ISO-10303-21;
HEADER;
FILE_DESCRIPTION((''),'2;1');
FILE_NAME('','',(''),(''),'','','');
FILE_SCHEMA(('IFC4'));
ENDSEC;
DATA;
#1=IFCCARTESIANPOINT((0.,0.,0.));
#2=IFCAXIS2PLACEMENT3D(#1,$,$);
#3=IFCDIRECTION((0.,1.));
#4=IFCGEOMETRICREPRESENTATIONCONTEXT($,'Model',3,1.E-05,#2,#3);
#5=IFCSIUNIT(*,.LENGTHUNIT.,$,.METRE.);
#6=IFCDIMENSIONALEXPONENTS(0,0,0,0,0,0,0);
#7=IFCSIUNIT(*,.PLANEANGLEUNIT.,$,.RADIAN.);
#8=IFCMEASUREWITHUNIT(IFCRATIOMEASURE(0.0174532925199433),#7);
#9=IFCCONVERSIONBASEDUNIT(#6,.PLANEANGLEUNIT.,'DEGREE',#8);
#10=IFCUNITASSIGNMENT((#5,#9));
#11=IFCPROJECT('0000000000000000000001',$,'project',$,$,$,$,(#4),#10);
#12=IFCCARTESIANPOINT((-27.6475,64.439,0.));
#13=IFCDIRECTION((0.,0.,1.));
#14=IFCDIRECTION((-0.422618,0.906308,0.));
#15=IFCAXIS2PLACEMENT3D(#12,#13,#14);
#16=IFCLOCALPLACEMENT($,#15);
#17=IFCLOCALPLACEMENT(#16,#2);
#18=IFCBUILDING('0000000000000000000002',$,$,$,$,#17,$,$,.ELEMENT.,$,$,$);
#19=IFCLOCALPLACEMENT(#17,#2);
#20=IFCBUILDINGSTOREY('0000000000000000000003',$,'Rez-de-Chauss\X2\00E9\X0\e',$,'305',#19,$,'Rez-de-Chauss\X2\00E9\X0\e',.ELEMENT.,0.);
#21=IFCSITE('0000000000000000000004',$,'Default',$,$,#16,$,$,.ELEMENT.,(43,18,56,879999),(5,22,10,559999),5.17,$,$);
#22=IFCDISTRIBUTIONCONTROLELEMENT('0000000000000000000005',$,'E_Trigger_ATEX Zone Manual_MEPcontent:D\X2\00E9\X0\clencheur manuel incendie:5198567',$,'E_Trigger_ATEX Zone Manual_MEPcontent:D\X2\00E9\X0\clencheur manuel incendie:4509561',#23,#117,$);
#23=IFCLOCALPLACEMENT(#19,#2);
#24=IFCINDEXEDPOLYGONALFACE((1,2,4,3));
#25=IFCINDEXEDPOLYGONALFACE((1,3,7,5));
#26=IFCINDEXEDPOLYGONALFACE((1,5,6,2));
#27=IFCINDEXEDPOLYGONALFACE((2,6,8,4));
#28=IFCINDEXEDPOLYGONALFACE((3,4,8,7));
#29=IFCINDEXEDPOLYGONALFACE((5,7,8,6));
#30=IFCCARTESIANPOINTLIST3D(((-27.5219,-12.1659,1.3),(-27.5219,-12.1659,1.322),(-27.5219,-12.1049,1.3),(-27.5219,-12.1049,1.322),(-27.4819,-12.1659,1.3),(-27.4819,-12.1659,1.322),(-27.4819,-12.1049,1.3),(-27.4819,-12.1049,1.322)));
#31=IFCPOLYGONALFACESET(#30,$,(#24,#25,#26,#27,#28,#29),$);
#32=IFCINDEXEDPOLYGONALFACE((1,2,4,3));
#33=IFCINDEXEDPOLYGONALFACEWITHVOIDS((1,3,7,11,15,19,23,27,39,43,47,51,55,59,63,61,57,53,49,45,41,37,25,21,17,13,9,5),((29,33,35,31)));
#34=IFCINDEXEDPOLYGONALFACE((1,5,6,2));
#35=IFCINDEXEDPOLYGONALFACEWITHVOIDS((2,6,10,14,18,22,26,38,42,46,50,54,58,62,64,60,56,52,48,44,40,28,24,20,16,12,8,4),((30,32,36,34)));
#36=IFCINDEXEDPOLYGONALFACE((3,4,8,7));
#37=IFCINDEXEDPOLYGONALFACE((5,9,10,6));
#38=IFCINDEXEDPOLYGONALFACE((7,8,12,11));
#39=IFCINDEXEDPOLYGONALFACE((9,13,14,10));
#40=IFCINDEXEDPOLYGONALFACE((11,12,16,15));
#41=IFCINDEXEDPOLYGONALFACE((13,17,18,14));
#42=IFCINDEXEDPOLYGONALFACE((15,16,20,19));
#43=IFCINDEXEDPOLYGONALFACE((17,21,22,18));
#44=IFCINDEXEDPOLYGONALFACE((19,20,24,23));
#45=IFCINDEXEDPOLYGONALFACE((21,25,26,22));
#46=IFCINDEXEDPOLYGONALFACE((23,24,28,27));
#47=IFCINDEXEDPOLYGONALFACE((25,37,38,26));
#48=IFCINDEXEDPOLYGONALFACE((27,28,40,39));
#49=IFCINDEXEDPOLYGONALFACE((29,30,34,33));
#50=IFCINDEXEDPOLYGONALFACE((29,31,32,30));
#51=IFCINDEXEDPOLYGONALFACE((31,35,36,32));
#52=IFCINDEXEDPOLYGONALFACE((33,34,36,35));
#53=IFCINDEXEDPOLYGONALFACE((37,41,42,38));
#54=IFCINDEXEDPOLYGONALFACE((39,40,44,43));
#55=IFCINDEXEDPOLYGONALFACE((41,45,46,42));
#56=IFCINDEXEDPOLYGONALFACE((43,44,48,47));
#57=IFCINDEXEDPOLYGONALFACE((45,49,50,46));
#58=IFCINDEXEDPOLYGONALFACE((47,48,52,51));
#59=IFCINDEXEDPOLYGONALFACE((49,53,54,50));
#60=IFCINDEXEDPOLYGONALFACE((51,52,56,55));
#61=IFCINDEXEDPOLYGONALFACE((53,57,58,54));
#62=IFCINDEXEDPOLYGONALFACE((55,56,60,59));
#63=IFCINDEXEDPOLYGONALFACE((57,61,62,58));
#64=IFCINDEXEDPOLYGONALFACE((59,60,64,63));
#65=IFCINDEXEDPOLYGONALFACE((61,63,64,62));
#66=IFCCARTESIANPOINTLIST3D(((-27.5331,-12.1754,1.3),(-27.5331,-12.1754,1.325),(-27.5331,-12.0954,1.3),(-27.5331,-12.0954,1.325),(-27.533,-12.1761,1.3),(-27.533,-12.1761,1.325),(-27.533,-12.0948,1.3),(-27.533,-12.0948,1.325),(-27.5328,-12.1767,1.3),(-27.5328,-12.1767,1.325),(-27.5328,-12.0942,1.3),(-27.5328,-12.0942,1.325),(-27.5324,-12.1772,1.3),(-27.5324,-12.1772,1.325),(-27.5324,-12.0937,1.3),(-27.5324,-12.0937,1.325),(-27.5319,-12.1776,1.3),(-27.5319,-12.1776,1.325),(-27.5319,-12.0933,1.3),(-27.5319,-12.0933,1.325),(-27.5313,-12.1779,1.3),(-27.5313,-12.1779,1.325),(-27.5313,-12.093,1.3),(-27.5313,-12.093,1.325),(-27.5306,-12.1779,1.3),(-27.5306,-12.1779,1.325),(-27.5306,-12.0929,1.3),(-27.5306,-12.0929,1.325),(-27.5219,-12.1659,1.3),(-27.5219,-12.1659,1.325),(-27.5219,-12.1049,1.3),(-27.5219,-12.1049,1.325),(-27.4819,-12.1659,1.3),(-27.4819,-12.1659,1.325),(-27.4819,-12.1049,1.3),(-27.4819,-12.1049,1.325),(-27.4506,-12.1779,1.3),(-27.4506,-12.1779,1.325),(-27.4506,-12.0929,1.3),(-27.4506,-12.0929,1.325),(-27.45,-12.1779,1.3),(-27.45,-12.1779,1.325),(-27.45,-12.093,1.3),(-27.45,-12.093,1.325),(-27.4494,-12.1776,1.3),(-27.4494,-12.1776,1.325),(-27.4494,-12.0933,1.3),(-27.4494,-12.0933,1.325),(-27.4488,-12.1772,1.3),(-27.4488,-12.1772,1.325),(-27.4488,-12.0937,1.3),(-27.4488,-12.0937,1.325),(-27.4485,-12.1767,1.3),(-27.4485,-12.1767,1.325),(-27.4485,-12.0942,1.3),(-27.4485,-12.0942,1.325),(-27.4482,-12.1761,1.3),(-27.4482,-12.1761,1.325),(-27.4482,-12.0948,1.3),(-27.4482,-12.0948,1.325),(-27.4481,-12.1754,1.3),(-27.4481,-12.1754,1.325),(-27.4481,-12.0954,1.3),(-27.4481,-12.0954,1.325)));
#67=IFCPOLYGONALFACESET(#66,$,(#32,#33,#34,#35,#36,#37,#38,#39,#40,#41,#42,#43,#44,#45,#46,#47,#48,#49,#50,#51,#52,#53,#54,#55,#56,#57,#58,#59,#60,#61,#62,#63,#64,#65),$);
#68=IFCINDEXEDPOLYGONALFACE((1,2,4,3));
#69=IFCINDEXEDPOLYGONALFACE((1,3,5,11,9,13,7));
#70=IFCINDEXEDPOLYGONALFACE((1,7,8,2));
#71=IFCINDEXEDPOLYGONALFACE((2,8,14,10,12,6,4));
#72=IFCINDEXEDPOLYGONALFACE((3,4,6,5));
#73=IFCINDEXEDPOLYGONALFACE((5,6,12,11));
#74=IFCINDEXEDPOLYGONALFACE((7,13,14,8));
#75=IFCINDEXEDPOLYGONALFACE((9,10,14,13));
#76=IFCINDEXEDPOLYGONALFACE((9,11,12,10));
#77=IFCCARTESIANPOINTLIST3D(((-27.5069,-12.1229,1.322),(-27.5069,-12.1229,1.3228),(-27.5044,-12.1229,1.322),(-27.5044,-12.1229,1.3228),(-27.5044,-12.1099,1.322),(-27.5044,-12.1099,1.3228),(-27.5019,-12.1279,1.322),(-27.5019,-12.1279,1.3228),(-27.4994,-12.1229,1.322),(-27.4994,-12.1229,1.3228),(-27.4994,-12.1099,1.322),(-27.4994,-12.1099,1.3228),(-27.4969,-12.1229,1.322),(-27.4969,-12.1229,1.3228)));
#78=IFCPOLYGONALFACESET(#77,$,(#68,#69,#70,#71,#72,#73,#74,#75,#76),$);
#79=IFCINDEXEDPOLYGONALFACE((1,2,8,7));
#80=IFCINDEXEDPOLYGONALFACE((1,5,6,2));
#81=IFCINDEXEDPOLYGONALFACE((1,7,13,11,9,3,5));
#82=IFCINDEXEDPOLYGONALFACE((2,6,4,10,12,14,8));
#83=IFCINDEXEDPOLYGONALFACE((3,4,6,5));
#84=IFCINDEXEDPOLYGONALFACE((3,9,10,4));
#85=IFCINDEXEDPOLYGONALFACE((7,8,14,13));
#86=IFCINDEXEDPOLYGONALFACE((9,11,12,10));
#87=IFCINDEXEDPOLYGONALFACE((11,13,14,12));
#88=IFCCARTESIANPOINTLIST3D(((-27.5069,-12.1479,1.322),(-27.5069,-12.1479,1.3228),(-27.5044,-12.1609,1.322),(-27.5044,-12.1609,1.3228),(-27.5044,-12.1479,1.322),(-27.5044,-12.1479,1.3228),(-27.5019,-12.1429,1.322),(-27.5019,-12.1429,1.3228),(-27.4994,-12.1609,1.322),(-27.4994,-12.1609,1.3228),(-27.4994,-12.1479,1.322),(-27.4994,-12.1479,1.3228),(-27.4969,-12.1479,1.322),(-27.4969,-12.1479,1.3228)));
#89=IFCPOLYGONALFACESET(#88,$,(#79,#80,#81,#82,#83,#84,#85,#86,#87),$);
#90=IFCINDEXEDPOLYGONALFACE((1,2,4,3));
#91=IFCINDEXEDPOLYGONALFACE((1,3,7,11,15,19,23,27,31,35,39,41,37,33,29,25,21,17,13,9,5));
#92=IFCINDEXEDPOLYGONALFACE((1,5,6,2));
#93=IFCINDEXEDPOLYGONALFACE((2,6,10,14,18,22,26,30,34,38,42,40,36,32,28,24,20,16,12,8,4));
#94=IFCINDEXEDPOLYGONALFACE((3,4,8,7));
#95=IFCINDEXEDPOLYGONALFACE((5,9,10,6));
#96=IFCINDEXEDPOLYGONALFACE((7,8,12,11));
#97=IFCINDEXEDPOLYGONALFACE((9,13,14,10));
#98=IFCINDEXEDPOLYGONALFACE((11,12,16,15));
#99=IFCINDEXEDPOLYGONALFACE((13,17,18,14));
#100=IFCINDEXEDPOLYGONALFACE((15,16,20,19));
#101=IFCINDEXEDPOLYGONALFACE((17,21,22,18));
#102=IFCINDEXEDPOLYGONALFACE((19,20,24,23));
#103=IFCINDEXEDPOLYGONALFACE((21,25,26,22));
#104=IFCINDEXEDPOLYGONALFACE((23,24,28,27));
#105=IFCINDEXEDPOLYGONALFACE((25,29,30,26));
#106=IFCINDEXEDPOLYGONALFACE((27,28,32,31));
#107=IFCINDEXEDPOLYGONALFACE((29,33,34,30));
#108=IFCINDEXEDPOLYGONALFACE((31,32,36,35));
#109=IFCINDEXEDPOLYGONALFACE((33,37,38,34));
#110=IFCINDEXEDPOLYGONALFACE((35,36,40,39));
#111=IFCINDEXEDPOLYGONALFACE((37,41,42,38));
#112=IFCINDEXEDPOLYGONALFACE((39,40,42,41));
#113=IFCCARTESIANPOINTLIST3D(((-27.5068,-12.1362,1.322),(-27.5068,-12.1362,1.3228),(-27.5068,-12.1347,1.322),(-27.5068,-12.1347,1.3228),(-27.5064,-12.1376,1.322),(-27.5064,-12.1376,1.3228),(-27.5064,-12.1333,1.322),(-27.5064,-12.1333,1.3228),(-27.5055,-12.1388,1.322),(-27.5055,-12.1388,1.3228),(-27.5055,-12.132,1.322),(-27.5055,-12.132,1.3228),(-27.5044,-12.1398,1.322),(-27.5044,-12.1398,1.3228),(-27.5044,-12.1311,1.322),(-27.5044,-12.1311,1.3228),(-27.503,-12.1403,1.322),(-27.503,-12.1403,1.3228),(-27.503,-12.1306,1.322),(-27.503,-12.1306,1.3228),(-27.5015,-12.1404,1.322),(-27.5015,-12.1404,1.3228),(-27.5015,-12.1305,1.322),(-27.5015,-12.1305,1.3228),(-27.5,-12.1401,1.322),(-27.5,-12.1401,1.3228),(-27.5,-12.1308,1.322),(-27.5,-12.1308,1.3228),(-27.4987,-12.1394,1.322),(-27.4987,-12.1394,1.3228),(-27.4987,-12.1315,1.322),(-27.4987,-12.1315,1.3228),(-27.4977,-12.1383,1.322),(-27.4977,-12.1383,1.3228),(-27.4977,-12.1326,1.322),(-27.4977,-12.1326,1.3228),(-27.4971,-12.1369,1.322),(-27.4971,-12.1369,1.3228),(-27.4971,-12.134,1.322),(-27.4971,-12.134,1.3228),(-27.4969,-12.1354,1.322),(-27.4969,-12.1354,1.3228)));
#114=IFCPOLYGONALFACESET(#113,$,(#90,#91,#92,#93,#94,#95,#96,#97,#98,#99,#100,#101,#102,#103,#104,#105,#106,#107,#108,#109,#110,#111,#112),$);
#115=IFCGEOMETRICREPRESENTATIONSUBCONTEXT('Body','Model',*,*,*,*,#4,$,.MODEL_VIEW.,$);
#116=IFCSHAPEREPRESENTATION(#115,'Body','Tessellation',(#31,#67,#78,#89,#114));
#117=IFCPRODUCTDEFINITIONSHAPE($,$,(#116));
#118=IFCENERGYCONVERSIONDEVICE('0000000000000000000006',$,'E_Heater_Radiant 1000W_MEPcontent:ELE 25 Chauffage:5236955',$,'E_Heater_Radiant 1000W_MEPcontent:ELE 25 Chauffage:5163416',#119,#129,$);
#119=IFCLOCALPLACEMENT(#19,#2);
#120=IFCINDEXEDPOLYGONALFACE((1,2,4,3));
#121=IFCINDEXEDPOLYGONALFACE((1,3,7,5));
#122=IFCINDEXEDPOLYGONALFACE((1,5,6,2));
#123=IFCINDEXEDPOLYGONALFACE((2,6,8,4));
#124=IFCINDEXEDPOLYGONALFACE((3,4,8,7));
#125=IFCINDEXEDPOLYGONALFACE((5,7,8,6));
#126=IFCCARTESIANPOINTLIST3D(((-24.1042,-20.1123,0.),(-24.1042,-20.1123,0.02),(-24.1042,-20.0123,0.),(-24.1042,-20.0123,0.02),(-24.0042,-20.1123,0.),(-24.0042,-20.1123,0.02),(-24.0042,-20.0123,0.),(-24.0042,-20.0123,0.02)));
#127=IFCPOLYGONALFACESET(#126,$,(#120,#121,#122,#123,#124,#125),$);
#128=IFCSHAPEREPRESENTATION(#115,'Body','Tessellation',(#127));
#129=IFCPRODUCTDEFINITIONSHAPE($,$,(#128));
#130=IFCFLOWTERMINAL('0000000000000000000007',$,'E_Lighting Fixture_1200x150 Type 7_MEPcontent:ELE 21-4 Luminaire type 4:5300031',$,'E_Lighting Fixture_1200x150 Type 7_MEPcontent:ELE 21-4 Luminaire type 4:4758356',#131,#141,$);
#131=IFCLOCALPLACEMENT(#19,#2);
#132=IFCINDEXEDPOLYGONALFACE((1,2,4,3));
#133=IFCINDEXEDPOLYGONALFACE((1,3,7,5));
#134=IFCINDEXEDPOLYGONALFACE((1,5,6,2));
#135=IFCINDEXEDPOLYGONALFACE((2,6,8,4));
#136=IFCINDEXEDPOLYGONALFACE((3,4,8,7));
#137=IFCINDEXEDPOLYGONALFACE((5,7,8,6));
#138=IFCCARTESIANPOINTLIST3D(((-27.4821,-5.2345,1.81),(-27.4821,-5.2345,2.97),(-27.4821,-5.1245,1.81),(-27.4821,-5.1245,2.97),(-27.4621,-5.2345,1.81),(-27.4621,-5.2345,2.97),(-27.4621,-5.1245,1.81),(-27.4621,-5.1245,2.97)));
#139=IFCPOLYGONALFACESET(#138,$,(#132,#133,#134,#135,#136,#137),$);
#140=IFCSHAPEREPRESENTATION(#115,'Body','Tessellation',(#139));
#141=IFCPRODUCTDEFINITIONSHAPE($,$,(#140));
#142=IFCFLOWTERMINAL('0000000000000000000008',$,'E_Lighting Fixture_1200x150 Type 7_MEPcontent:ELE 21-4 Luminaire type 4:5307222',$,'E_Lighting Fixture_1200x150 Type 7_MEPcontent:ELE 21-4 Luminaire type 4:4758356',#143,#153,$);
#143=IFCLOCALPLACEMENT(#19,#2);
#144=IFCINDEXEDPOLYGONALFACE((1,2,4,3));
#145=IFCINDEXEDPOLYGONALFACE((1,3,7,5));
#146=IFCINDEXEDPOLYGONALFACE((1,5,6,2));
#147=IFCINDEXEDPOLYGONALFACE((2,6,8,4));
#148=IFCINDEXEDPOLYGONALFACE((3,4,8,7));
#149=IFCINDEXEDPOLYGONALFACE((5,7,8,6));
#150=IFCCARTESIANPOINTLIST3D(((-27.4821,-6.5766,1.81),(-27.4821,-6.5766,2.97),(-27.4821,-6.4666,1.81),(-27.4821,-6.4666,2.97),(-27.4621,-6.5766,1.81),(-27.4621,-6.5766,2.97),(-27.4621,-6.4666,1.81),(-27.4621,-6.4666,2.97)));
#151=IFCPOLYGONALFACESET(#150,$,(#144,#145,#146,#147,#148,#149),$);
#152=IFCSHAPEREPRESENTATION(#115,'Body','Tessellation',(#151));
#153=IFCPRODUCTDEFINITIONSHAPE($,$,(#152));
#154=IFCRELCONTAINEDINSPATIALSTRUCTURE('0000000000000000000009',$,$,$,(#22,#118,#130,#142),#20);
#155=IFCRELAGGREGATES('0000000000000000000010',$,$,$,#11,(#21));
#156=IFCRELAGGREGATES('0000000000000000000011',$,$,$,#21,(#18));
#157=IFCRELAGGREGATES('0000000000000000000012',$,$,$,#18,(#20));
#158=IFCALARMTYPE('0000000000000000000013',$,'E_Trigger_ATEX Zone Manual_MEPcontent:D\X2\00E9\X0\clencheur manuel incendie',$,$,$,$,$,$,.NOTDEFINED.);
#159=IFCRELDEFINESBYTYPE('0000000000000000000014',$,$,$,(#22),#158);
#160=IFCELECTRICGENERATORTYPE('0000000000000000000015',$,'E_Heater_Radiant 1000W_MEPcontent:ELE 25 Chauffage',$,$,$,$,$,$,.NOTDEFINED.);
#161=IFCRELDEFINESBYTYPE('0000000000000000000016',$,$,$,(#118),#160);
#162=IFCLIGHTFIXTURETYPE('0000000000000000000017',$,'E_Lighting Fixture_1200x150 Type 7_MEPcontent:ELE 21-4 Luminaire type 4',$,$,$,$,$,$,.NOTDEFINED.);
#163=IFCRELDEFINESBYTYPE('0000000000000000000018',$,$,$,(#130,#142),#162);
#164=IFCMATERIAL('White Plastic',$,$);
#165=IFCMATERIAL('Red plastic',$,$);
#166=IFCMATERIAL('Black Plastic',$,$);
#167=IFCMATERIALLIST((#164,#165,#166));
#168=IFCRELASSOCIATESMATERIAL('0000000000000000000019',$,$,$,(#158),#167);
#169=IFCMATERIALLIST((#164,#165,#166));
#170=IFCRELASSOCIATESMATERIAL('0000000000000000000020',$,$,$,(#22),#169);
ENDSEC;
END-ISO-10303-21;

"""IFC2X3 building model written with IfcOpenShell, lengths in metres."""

from ifc_helpers import new_model, entity, si_unit, converted_unit, direction, frame, frame_2d, origin, origin_2d_with_axis, place, context, subcontext, project, spatial, polyline, circle_curve, parameter, trimmed, segment, composite_curve, rectangle, circle, outline, extrude, source, transform, mapped, material, material_list, type_object, type_shapes, element, save


model = new_model("IFC2X3")

# Units and contexts
model_context = context("Model", 3, precision=1e-05, world=origin(), true_north=direction((0.0, 1.0)))
body_context = subcontext(model_context, "Body", "Model", "MODEL_VIEW")
ifc_project = project(units=[si_unit("LENGTHUNIT", "METRE"), converted_unit("PLANEANGLEUNIT", "DEGREE", entity("IfcRatioMeasure", 0.0174532925199433), si_unit("PLANEANGLEUNIT", "RADIAN"), dimensions=[0, 0, 0, 0, 0, 0, 0])], contexts=[model_context])

# Site, building, storey
site_placement = place(None, frame((-27.6475, 64.439, 0.0), z_axis=(0.0, 0.0, 1.0), x_axis=(-0.422618, 0.906308, 0.0)))
site = spatial("IfcSite", under=ifc_project, at=site_placement, Name="Default", CompositionType="ELEMENT", RefLatitude=(43, 18, 56, 879999), RefLongitude=(5, 22, 10, 559999), RefElevation=5.17)
building_placement = place(site_placement, origin())
building = spatial("IfcBuilding", under=site, at=building_placement, CompositionType="ELEMENT")
storey_placement = place(building_placement, origin())
storey = spatial("IfcBuildingStorey", under=building, at=storey_placement, Name="Rez-de-Chaussée", ObjectType="305", LongName="Rez-de-Chaussée", CompositionType="ELEMENT", Elevation=0.0)

# Distribution control element
ifc_material_1 = material(Name="White Plastic")
ifc_material_2 = material(Name="Red plastic")
ifc_material_3 = material(Name="Black Plastic")
ifc_material_list_1 = material_list([ifc_material_1, ifc_material_2, ifc_material_3])
ifc_material_list_2 = material_list([ifc_material_1, ifc_material_2, ifc_material_3])
alarm_type_1 = type_object("IfcAlarmType", Name="E_Trigger_ATEX Zone Manual_MEPcontent:Déclencheur manuel incendie", PredefinedType="NOTDEFINED", material=ifc_material_list_2)
shared_shape_1 = source(origin(), body_context, "Body", "SweptSolid", [
    extrude(rectangle(XDim=0.061, YDim=0.04, at=origin_2d_with_axis()), frame((0.0, 0.0112, 0.0)), (0.0, 0.0, 1.0), 0.022),
    extrude(outline(composite_curve([segment(polyline([(-0.04, -0.0425), (0.04, -0.0425)]), True, "CONTINUOUS"), segment(trimmed(circle_curve(frame_2d((0.04, -0.04), x_axis=(-1.0, 0.0)), 0.0025), [parameter(90.0)], [parameter(180.0)], True, "PARAMETER"), True, "CONTINUOUS"), segment(polyline([(0.0425, -0.04), (0.0425, 0.04)]), True, "CONTINUOUS"), segment(trimmed(circle_curve(frame_2d((0.04, 0.04), x_axis=(-1.0, 0.0)), 0.0025), [parameter(180.0)], [parameter(270.0)], True, "PARAMETER"), True, "CONTINUOUS"), segment(polyline([(0.04, 0.0425), (-0.04, 0.0425)]), True, "CONTINUOUS"), segment(trimmed(circle_curve(frame_2d((-0.04, 0.04), x_axis=(-1.0, 0.0)), 0.0025), [parameter(270.0)], [parameter(0.0)], True, "PARAMETER"), True, "CONTINUOUS"), segment(polyline([(-0.0425, 0.04), (-0.0425, -0.04)]), True, "CONTINUOUS"), segment(trimmed(circle_curve(frame_2d((-0.04, -0.04), x_axis=(-1.0, 0.0)), 0.0025), [parameter(360.0)], [parameter(90.0)], True, "PARAMETER"), True, "CONTINUOUS")], self_intersect=False), holes=[polyline([(-0.0305, -0.0088), (-0.0305, 0.0312), (0.0305, 0.0312), (0.0305, -0.0088), (-0.0305, -0.0088)])]), origin(), (0.0, 0.0, 1.0), 0.025),
    extrude(outline(polyline([(-0.01, 0.0025), (-0.01, -0.0025), (0.003, -0.0025), (0.003, -0.005), (0.008, 0.0), (0.003, 0.005), (0.003, 0.0025), (-0.01, 0.0025)])), frame((0.0155, 0.0112, 0.022), z_axis=(0.0, 0.0, -1.0), x_axis=(-1.0, 0.0, 0.0)), (0.0, 0.0, -1.0), 0.0008),
    extrude(outline(polyline([(-0.0014, -0.0057), (0.0057, -0.0057), (0.0057, 0.0014), (0.0039, -0.0004), (-0.0053, 0.0088), (-0.0088, 0.0053), (0.0004, -0.0039), (-0.0014, -0.0057)])), frame((-0.0155, 0.0112, 0.022), z_axis=(0.0, 0.0, 1.0), x_axis=(0.707107, 0.707107, 0.0)), (0.0, 0.0, 1.0), 0.0008),
    extrude(circle(Radius=0.005, at=frame_2d((0.0, 0.0), x_axis=(1.0, 0.0))), frame((0.0, 0.0112, 0.022), z_axis=(0.0, 0.0, 1.0), x_axis=(0.0, -1.0, 0.0)), (0.0, 0.0, 1.0), 0.0008),
])
type_shapes(alarm_type_1, [shared_shape_1])
distribution_control_element_1_placement = place(storey_placement, frame((-27.4906, -12.1354, 1.3), z_axis=(0.0, 0.0, 1.0), x_axis=(0.0, 1.0, 0.0)))
element("IfcDistributionControlElement", 1, at=distribution_control_element_1_placement, inside=storey, type_object=alarm_type_1, material=ifc_material_list_1, Name="E_Trigger_ATEX Zone Manual_MEPcontent:Déclencheur manuel incendie:5198567", ObjectType="E_Trigger_ATEX Zone Manual_MEPcontent:Déclencheur manuel incendie:4509561", context=body_context, shape_type="MappedRepresentation", body=[
    mapped(shared_shape_1, transform((0.0, 0.0, 0.0), scale=1.0)),
])

# Energy conversion device
electric_generator_type_1 = type_object("IfcElectricGeneratorType", Name="E_Heater_Radiant 1000W_MEPcontent:ELE 25 Chauffage", PredefinedType="NOTDEFINED")
shared_shape_2 = source(origin(), body_context, "Body", "SweptSolid", [
    extrude(rectangle(XDim=0.1, YDim=0.1, at=origin_2d_with_axis()), frame((0.0, 0.0, 0.0), z_axis=(0.0, 0.0, 1.0), x_axis=(0.0, -1.0, 0.0)), (0.0, 0.0, 1.0), 0.02),
])
type_shapes(electric_generator_type_1, [shared_shape_2])
energy_conversion_device_placement = place(storey_placement, frame((-24.0542, -20.0623, 0.0)))
element("IfcEnergyConversionDevice", 2, at=energy_conversion_device_placement, inside=storey, type_object=electric_generator_type_1, Name="E_Heater_Radiant 1000W_MEPcontent:ELE 25 Chauffage:5236955", ObjectType="E_Heater_Radiant 1000W_MEPcontent:ELE 25 Chauffage:5163416", context=body_context, shape_type="MappedRepresentation", body=[
    mapped(shared_shape_2, transform((0.0, 0.0, 0.0), scale=1.0)),
])

# Flow terminals
light_fixture_type_1 = type_object("IfcLightFixtureType", Name="E_Lighting Fixture_1200x150 Type 7_MEPcontent:ELE 21-4 Luminaire type 4", PredefinedType="NOTDEFINED")
shared_shape_3 = source(origin(), body_context, "Body", "SweptSolid", [
    extrude(rectangle(XDim=0.02, YDim=0.11, at=frame_2d((0.0, 0.0), x_axis=(1.0, 0.0))), frame((-0.01, 0.0, -0.58)), (0.0, 0.0, 1.0), 1.16),
])
type_shapes(light_fixture_type_1, [shared_shape_3])
for number, where, name in (
    (3, (-27.4621, -5.1795, 2.39), "E_Lighting Fixture_1200x150 Type 7_MEPcontent:ELE 21-4 Luminaire type 4:5300031"),
    (4, (-27.4621, -6.5216, 2.39), "E_Lighting Fixture_1200x150 Type 7_MEPcontent:ELE 21-4 Luminaire type 4:5307222"),
):
    element("IfcFlowTerminal", number, at=place(storey_placement, frame(where)), inside=storey, type_object=light_fixture_type_1, Name=name, ObjectType="E_Lighting Fixture_1200x150 Type 7_MEPcontent:ELE 21-4 Luminaire type 4:4758356", context=body_context, shape_type="MappedRepresentation", body=[
        mapped(shared_shape_3, transform((0.0, 0.0, 0.0), scale=1.0)),
    ])

save(model, "model.ifc")
